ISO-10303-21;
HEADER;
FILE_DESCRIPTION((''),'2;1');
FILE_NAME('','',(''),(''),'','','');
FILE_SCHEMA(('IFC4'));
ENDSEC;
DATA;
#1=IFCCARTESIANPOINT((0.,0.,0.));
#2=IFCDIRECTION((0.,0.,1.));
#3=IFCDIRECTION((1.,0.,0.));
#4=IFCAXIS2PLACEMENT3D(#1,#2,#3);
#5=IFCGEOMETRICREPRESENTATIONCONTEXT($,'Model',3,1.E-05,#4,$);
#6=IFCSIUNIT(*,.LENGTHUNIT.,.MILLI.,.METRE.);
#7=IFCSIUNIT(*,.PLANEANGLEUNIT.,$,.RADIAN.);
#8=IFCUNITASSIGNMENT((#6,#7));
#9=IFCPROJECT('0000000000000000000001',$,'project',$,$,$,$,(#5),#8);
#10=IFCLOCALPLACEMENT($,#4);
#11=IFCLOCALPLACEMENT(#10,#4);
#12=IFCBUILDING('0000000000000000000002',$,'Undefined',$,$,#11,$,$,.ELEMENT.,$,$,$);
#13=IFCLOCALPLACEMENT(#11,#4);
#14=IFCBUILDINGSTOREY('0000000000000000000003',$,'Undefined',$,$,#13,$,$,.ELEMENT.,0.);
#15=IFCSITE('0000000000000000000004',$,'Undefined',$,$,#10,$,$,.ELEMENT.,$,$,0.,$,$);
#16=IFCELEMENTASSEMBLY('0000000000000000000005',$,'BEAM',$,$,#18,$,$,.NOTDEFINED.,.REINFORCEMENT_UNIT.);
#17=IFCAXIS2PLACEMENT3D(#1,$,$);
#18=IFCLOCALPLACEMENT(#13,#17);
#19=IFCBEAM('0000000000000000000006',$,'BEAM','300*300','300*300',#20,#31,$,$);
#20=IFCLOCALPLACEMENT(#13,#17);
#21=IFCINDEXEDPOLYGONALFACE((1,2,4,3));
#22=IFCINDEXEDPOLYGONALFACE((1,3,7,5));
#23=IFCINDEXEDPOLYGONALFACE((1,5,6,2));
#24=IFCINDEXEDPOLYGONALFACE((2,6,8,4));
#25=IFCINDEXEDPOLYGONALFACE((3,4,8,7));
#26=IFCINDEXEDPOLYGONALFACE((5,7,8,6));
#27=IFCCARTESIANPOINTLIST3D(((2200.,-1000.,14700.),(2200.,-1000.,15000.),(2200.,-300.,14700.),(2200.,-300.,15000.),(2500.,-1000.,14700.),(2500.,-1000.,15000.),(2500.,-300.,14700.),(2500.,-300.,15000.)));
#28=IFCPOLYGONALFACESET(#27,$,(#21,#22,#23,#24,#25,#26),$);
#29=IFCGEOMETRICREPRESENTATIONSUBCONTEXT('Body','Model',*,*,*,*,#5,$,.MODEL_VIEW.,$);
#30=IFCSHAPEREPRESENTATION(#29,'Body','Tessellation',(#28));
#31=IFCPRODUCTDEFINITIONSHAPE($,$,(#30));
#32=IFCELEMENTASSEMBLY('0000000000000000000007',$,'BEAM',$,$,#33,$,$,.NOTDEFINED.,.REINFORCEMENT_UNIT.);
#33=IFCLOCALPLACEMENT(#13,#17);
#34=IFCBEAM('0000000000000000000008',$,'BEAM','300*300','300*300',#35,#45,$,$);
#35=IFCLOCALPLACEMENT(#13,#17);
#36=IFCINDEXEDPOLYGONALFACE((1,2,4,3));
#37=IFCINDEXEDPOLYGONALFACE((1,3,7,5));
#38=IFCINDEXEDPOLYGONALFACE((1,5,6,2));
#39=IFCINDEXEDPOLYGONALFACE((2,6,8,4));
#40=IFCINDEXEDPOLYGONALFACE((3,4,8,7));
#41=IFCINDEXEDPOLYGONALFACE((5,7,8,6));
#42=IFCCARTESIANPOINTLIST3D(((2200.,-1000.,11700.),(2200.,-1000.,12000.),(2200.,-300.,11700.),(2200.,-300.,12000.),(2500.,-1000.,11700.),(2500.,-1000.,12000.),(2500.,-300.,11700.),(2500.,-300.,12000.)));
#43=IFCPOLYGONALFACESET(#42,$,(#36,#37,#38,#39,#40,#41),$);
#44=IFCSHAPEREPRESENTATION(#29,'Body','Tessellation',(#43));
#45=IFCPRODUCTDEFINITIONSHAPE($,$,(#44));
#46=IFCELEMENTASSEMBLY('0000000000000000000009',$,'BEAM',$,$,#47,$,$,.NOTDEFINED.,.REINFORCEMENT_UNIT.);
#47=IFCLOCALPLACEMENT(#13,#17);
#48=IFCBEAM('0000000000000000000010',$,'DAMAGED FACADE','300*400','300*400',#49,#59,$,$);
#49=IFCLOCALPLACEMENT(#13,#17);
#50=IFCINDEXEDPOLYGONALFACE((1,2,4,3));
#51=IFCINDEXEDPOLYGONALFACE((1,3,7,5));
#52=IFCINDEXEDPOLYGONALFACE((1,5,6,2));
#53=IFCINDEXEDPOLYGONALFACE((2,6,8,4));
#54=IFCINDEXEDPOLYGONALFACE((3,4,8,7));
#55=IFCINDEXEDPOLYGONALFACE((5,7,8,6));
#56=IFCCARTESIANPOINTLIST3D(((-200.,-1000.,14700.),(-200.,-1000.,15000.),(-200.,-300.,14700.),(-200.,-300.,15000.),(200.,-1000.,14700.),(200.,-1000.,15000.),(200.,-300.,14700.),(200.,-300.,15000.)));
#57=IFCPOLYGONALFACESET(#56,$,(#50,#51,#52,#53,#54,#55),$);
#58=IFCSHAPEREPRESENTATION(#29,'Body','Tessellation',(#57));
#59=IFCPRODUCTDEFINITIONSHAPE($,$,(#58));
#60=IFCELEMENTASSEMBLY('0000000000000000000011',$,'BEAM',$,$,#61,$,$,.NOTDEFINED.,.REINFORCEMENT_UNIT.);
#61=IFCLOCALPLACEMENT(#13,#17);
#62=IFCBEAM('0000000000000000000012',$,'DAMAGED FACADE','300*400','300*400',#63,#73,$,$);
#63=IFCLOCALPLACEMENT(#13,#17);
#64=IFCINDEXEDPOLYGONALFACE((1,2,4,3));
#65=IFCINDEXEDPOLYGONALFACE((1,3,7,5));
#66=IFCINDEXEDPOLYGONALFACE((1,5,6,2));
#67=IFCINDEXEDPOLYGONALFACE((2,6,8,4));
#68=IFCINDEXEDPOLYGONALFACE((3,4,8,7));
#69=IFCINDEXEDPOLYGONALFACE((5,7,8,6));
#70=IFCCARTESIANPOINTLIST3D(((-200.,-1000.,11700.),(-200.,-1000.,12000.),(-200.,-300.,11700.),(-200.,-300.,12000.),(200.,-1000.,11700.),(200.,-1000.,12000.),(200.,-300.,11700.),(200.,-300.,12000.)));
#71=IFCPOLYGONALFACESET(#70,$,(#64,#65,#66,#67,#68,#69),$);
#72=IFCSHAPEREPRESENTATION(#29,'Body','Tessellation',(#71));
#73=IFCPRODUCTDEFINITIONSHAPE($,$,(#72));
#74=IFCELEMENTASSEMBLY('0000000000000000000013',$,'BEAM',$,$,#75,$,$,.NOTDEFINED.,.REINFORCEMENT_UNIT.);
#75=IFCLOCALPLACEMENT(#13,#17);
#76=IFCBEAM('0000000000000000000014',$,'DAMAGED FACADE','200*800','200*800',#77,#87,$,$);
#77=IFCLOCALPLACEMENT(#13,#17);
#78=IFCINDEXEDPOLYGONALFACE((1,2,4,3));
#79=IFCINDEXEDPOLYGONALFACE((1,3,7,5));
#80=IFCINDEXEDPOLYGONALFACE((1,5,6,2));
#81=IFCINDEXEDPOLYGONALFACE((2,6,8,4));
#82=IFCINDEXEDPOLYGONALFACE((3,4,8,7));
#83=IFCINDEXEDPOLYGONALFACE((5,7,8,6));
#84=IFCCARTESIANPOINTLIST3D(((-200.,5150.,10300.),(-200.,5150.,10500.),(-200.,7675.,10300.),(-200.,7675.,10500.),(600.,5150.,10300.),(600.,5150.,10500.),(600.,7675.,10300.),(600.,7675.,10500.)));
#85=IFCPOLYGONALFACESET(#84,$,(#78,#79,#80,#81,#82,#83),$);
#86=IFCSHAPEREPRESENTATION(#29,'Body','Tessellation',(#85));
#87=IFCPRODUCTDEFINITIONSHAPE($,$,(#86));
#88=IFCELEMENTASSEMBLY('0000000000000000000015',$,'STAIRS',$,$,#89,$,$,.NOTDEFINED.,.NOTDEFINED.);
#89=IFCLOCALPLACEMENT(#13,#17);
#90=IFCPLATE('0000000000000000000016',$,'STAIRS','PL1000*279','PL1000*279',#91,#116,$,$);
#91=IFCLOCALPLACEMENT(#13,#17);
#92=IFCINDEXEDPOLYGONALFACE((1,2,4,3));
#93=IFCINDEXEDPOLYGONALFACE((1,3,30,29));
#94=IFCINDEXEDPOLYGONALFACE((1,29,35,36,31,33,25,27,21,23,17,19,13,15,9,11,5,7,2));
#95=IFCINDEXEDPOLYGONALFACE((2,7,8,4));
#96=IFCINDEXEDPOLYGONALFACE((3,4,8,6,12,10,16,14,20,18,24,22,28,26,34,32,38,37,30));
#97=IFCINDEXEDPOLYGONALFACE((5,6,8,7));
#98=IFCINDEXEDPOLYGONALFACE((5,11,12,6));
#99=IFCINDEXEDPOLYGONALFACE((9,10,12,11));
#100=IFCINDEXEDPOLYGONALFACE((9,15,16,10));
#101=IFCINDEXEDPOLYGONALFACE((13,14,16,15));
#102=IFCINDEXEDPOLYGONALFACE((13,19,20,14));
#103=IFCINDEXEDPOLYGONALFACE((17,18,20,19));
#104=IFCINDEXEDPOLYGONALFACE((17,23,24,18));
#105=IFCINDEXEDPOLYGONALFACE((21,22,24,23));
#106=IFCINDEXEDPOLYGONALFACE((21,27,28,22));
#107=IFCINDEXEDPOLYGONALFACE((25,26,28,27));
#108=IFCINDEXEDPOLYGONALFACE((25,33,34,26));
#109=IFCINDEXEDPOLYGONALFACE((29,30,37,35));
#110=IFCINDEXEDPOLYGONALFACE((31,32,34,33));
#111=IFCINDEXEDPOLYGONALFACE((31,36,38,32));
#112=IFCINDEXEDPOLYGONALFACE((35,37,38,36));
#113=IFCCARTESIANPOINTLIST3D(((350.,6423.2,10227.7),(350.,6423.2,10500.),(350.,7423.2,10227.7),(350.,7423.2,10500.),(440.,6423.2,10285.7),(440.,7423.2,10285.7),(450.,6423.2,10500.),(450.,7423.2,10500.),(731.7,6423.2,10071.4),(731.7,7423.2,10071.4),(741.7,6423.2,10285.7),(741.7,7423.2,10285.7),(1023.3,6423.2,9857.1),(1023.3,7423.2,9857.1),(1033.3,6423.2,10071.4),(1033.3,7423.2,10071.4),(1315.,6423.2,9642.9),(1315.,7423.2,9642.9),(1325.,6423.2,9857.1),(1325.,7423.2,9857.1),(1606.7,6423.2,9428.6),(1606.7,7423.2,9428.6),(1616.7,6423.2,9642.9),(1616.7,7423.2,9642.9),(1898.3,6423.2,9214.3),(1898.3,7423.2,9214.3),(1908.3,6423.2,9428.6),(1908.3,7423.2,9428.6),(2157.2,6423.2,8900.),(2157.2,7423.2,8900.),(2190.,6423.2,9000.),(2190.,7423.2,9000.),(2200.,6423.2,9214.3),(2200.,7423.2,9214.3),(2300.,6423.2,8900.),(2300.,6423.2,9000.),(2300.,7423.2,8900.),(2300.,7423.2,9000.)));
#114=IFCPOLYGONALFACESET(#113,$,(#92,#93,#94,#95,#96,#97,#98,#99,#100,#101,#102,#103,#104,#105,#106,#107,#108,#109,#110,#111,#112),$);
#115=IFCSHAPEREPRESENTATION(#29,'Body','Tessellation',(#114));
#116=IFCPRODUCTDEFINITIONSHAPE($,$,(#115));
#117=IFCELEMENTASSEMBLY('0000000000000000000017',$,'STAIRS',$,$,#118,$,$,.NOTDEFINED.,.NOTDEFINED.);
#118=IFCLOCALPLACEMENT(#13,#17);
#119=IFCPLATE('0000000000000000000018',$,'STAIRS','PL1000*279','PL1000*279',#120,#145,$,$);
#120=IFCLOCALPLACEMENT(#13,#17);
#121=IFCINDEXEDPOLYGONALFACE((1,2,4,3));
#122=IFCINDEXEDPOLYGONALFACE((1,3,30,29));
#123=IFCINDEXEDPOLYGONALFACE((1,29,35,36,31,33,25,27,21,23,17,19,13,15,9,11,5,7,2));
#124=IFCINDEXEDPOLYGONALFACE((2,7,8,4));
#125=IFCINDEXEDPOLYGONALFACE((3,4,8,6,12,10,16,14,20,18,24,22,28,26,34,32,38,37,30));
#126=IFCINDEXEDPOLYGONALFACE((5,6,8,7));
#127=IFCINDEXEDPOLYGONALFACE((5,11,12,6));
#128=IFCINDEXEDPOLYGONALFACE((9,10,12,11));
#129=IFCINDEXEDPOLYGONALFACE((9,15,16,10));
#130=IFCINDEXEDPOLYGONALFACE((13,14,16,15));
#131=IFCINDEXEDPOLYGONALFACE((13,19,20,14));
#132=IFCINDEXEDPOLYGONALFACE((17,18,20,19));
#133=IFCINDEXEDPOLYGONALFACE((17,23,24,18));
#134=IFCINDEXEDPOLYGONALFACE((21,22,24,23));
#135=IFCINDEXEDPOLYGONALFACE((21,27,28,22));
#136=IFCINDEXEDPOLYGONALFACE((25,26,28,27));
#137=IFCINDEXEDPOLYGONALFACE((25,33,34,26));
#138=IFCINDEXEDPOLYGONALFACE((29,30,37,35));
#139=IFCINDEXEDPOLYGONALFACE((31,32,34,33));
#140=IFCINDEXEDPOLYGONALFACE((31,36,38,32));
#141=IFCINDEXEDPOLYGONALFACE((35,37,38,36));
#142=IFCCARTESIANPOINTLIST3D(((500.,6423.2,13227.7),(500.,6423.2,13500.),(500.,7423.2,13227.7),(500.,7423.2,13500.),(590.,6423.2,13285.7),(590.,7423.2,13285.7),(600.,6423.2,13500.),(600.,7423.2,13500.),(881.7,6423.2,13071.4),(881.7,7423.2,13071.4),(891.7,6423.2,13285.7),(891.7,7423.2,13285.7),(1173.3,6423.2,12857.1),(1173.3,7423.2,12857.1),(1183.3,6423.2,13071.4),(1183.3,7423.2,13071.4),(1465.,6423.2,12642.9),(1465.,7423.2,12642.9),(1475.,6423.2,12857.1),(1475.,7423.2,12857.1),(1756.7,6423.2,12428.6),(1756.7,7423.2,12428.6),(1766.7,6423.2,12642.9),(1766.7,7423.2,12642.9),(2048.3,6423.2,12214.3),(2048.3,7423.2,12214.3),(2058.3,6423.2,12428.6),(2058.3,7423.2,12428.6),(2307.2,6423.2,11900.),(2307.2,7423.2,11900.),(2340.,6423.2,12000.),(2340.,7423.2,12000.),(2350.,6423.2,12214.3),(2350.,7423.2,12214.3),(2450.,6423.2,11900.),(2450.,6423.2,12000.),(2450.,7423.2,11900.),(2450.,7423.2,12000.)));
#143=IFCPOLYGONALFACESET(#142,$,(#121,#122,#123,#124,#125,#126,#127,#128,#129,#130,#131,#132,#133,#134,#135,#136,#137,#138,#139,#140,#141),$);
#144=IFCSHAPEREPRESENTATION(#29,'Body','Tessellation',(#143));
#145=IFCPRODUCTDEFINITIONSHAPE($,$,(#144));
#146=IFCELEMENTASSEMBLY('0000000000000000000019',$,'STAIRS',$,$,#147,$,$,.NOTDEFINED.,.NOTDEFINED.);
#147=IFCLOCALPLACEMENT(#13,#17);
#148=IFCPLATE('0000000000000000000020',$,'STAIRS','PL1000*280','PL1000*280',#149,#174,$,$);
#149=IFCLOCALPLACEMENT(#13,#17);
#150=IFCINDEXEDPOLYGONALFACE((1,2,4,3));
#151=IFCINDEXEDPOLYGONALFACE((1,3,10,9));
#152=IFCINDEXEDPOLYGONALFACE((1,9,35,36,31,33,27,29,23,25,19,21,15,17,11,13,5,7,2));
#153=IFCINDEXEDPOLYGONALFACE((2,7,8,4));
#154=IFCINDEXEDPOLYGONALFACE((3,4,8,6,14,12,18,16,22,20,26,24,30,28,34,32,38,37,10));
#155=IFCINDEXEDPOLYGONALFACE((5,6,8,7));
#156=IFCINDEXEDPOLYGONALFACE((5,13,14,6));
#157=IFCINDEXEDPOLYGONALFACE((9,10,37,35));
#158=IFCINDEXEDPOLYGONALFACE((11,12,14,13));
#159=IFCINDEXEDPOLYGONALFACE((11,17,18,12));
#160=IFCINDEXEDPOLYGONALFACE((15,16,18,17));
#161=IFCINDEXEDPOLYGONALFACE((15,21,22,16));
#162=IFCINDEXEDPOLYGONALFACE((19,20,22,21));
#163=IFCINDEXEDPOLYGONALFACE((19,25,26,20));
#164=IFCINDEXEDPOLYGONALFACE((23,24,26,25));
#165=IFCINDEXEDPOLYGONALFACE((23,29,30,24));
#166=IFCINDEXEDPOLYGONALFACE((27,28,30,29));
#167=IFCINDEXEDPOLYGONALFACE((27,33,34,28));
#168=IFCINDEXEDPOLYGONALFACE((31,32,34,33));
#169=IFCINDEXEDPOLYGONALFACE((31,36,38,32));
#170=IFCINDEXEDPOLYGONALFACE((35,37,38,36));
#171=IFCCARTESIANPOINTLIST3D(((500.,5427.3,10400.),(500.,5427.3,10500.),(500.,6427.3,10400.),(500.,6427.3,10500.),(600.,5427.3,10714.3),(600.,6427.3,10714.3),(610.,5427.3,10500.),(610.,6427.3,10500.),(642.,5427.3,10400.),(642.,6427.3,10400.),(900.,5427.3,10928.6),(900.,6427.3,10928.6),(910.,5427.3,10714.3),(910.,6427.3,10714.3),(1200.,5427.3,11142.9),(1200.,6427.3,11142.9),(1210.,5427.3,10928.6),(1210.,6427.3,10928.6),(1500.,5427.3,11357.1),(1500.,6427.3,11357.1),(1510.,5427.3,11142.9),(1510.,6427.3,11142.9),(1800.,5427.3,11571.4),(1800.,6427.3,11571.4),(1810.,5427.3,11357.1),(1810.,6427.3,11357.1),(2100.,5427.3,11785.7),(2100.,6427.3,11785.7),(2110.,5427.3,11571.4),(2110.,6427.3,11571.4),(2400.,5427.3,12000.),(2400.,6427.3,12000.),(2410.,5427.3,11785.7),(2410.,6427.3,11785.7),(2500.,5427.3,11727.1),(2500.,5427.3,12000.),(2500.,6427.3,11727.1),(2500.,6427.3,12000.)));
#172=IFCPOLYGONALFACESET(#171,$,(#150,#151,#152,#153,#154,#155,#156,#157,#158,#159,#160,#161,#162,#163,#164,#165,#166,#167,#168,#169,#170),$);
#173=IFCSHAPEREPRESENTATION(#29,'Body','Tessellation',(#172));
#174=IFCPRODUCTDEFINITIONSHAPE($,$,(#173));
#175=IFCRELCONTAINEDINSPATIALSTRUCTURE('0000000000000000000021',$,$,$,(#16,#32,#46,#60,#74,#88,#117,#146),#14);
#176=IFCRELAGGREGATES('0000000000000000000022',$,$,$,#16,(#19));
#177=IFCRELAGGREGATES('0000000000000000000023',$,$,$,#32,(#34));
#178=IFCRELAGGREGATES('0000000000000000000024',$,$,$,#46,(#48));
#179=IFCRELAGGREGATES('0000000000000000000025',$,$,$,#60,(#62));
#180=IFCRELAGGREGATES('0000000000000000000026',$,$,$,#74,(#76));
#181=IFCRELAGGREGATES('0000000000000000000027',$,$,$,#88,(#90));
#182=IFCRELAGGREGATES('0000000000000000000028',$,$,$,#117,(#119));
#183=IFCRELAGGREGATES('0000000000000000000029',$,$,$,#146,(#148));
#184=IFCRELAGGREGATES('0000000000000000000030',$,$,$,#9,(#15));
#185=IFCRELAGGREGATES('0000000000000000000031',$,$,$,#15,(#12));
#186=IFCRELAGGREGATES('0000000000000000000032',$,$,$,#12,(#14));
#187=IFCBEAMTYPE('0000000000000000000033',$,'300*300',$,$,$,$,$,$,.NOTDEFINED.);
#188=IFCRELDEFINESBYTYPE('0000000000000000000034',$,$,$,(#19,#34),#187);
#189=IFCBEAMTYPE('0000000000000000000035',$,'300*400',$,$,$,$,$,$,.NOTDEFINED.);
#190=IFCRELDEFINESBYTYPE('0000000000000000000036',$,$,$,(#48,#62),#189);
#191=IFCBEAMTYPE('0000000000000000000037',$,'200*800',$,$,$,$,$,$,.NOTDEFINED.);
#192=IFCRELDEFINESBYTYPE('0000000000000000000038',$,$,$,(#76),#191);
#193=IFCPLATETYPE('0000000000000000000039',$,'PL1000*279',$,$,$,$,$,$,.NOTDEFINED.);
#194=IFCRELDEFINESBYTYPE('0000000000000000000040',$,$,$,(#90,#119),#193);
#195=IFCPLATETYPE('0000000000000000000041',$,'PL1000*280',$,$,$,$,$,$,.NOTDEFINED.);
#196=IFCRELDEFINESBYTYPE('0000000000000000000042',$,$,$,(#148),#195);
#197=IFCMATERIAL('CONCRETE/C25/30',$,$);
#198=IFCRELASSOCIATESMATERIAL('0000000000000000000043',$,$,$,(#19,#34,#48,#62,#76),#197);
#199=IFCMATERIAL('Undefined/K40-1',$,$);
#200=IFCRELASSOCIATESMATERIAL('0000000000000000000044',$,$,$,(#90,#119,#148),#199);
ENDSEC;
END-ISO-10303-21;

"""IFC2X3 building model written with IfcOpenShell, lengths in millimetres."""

from ifc_helpers import new_model, si_unit, frame, origin_with_axes, origin_2d_with_axis, place, context, subcontext, project, spatial, polyline, rectangle, outline, extrude, material, type_object, element, aggregate, save


model = new_model("IFC2X3")

# Units and contexts
model_context = context("Model", 3, precision=1e-05, world=origin_with_axes())
body_context = subcontext(model_context, "Body", "Model", "MODEL_VIEW")
ifc_project = project(units=[si_unit("LENGTHUNIT", "METRE", prefix="MILLI"), si_unit("PLANEANGLEUNIT", "RADIAN")], contexts=[model_context])

# Site, building, storey
site_placement = place(None, origin_with_axes())
site = spatial("IfcSite", under=ifc_project, at=site_placement, Name="Undefined", CompositionType="ELEMENT", RefElevation=0.0)
building_placement = place(site_placement, origin_with_axes())
building = spatial("IfcBuilding", under=site, at=building_placement, Name="Undefined", CompositionType="ELEMENT")
storey_placement = place(building_placement, origin_with_axes())
storey = spatial("IfcBuildingStorey", under=building, at=storey_placement, Name="Undefined", CompositionType="ELEMENT", Elevation=0.0)

# Shared definitions
ifc_material_1 = material(Name="CONCRETE/C25/30")

# Element assemblies, beams
beam_type_1 = type_object("IfcBeamType", Name="300*300", PredefinedType="NOTDEFINED")
assembly_1_placement = place(storey_placement, origin_with_axes())
assembly_1 = element("IfcElementAssembly", 1, at=assembly_1_placement, inside=storey, Name="BEAM", AssemblyPlace="NOTDEFINED", PredefinedType="REINFORCEMENT_UNIT")
beam_1_placement = place(assembly_1_placement, frame((2350.0, -300.0, 14850.0), z_axis=(0.0, 0.0, 1.0), x_axis=(0.0, -1.0, 0.0)))
beam_1 = element("IfcBeam", 2, at=beam_1_placement, type_object=beam_type_1, material=ifc_material_1, Name="BEAM", Description="300*300", ObjectType="300*300", context=body_context, shape_type="SweptSolid", body=[
    extrude(rectangle(XDim=300.0, YDim=300.0, at=origin_2d_with_axis()), frame((700.0, 0.0, 0.0), z_axis=(-1.0, 0.0, 0.0), x_axis=(0.0, -1.0, 0.0)), (0.0, 0.0, 1.0), 700.0),
])
aggregate(assembly_1, [beam_1])
assembly_2_placement = place(storey_placement, origin_with_axes())
assembly_2 = element("IfcElementAssembly", 3, at=assembly_2_placement, inside=storey, Name="BEAM", AssemblyPlace="NOTDEFINED", PredefinedType="REINFORCEMENT_UNIT")
beam_2_placement = place(assembly_2_placement, frame((2350.0, -300.0, 11850.0), z_axis=(0.0, 0.0, 1.0), x_axis=(0.0, -1.0, 0.0)))
beam_2 = element("IfcBeam", 4, at=beam_2_placement, type_object=beam_type_1, material=ifc_material_1, Name="BEAM", Description="300*300", ObjectType="300*300", context=body_context, shape_type="SweptSolid", body=[
    extrude(rectangle(XDim=300.0, YDim=300.0, at=origin_2d_with_axis()), frame((700.0, 0.0, 0.0), z_axis=(-1.0, 0.0, 0.0), x_axis=(0.0, -1.0, 0.0)), (0.0, 0.0, 1.0), 700.0),
])
aggregate(assembly_2, [beam_2])
assembly_3_placement = place(storey_placement, origin_with_axes())
assembly_3 = element("IfcElementAssembly", 5, at=assembly_3_placement, inside=storey, Name="BEAM", AssemblyPlace="NOTDEFINED", PredefinedType="REINFORCEMENT_UNIT")
beam_type_2 = type_object("IfcBeamType", Name="300*400", PredefinedType="NOTDEFINED")
beam_3_placement = place(assembly_3_placement, frame((0.0, -300.0, 14850.0), z_axis=(0.0, 0.0, 1.0), x_axis=(0.0, -1.0, 0.0)))
beam_3 = element("IfcBeam", 6, at=beam_3_placement, type_object=beam_type_2, material=ifc_material_1, Name="DAMAGED FACADE", Description="300*400", ObjectType="300*400", context=body_context, shape_type="SweptSolid", body=[
    extrude(rectangle(XDim=400.0, YDim=300.0, at=origin_2d_with_axis()), frame((700.0, 0.0, 0.0), z_axis=(-1.0, 0.0, 0.0), x_axis=(0.0, -1.0, 0.0)), (0.0, 0.0, 1.0), 700.0),
])
aggregate(assembly_3, [beam_3])
assembly_4_placement = place(storey_placement, origin_with_axes())
assembly_4 = element("IfcElementAssembly", 7, at=assembly_4_placement, inside=storey, Name="BEAM", AssemblyPlace="NOTDEFINED", PredefinedType="REINFORCEMENT_UNIT")
beam_4_placement = place(assembly_4_placement, frame((0.0, -300.0, 11850.0), z_axis=(0.0, 0.0, 1.0), x_axis=(0.0, -1.0, 0.0)))
beam_4 = element("IfcBeam", 8, at=beam_4_placement, type_object=beam_type_2, material=ifc_material_1, Name="DAMAGED FACADE", Description="300*400", ObjectType="300*400", context=body_context, shape_type="SweptSolid", body=[
    extrude(rectangle(XDim=400.0, YDim=300.0, at=origin_2d_with_axis()), frame((700.0, 0.0, 0.0), z_axis=(-1.0, 0.0, 0.0), x_axis=(0.0, -1.0, 0.0)), (0.0, 0.0, 1.0), 700.0),
])
aggregate(assembly_4, [beam_4])
assembly_5_placement = place(storey_placement, origin_with_axes())
assembly_5 = element("IfcElementAssembly", 9, at=assembly_5_placement, inside=storey, Name="BEAM", AssemblyPlace="NOTDEFINED", PredefinedType="REINFORCEMENT_UNIT")
beam_type_3 = type_object("IfcBeamType", Name="200*800", PredefinedType="NOTDEFINED")
beam_5_placement = place(assembly_5_placement, frame((200.0, 7675.0, 10400.0), z_axis=(0.0, 0.0, 1.0), x_axis=(0.0, -1.0, 0.0)))
beam_5 = element("IfcBeam", 10, at=beam_5_placement, type_object=beam_type_3, material=ifc_material_1, Name="DAMAGED FACADE", Description="200*800", ObjectType="200*800", context=body_context, shape_type="SweptSolid", body=[
    extrude(rectangle(XDim=800.0, YDim=200.0, at=origin_2d_with_axis()), frame((2525.0, 0.0, 0.0), z_axis=(-1.0, 0.0, 0.0), x_axis=(0.0, -1.0, 0.0)), (0.0, 0.0, 1.0), 2525.0),
])
aggregate(assembly_5, [beam_5])

# Element assemblies, plates
assembly_6_placement = place(storey_placement, origin_with_axes())
assembly_6 = element("IfcElementAssembly", 11, at=assembly_6_placement, inside=storey, Name="STAIRS", AssemblyPlace="NOTDEFINED", PredefinedType="NOTDEFINED")
ifc_material_2 = material(Name="Undefined/K40-1")
plate_type_1 = type_object("IfcPlateType", Name="PL1000*279", PredefinedType="NOTDEFINED")
plate_1_placement = place(assembly_6_placement, frame((2190.0, 6923.2, 9000.0), z_axis=(0.0, 1.0, 0.0), x_axis=(1.0, 0.0, 0.0)))
plate_1 = element("IfcPlate", 12, at=plate_1_placement, type_object=plate_type_1, material=ifc_material_2, Name="STAIRS", Description="PL1000*279", ObjectType="PL1000*279", context=body_context, shape_type="SweptSolid", body=[
    extrude(outline(polyline([(0.0, 0.0), (110.0, 0.0), (110.0, 100.0), (-32.8, 100.0), (-1840.0, -1227.7), (-1840.0, -1500.0), (-1740.0, -1500.0), (-1750.0, -1285.7), (-1448.3, -1285.7), (-1458.3, -1071.4), (-1156.7, -1071.4), (-1166.7, -857.1), (-865.0, -857.1), (-875.0, -642.9), (-573.3, -642.9), (-583.3, -428.6), (-281.7, -428.6), (-291.7, -214.3), (10.0, -214.3), (0.0, 0.0), (0.0, 0.0)])), frame((0.0, 0.0, -500.0), z_axis=(0.0, 0.0, 1.0), x_axis=(1.0, 0.0, 0.0)), (0.0, 0.0, 1.0), 1000.0),
])
aggregate(assembly_6, [plate_1])
assembly_7_placement = place(storey_placement, origin_with_axes())
assembly_7 = element("IfcElementAssembly", 13, at=assembly_7_placement, inside=storey, Name="STAIRS", AssemblyPlace="NOTDEFINED", PredefinedType="NOTDEFINED")
plate_2_placement = place(assembly_7_placement, frame((2340.0, 6923.2, 12000.0), z_axis=(0.0, 1.0, 0.0), x_axis=(1.0, 0.0, 0.0)))
plate_2 = element("IfcPlate", 14, at=plate_2_placement, type_object=plate_type_1, material=ifc_material_2, Name="STAIRS", Description="PL1000*279", ObjectType="PL1000*279", context=body_context, shape_type="SweptSolid", body=[
    extrude(outline(polyline([(0.0, 0.0), (110.0, 0.0), (110.0, 100.0), (-32.8, 100.0), (-1840.0, -1227.7), (-1840.0, -1500.0), (-1740.0, -1500.0), (-1750.0, -1285.7), (-1448.3, -1285.7), (-1458.3, -1071.4), (-1156.7, -1071.4), (-1166.7, -857.1), (-865.0, -857.1), (-875.0, -642.9), (-573.3, -642.9), (-583.3, -428.6), (-281.7, -428.6), (-291.7, -214.3), (10.0, -214.3), (0.0, 0.0), (0.0, 0.0)])), frame((0.0, 0.0, -500.0), z_axis=(0.0, 0.0, 1.0), x_axis=(1.0, 0.0, 0.0)), (0.0, 0.0, 1.0), 1000.0),
])
aggregate(assembly_7, [plate_2])
assembly_8_placement = place(storey_placement, origin_with_axes())
assembly_8 = element("IfcElementAssembly", 15, at=assembly_8_placement, inside=storey, Name="STAIRS", AssemblyPlace="NOTDEFINED", PredefinedType="NOTDEFINED")
plate_type_2 = type_object("IfcPlateType", Name="PL1000*280", PredefinedType="NOTDEFINED")
plate_3_placement = place(assembly_8_placement, frame((610.0, 5927.3, 10500.0), z_axis=(0.0, -1.0, 0.0), x_axis=(-1.0, 0.0, 0.0)))
plate_3 = element("IfcPlate", 16, at=plate_3_placement, type_object=plate_type_2, material=ifc_material_2, Name="STAIRS", Description="PL1000*280", ObjectType="PL1000*280", context=body_context, shape_type="SweptSolid", body=[
    extrude(outline(polyline([(0.0, 0.0), (110.0, 0.0), (110.0, 100.0), (-32.0, 100.0), (-1890.0, -1227.1), (-1890.0, -1500.0), (-1790.0, -1500.0), (-1800.0, -1285.7), (-1490.0, -1285.7), (-1500.0, -1071.4), (-1190.0, -1071.4), (-1200.0, -857.1), (-890.0, -857.1), (-900.0, -642.9), (-590.0, -642.9), (-600.0, -428.6), (-290.0, -428.6), (-300.0, -214.3), (10.0, -214.3), (0.0, 0.0), (0.0, 0.0)])), frame((0.0, 0.0, -500.0), z_axis=(0.0, 0.0, 1.0), x_axis=(1.0, 0.0, 0.0)), (0.0, 0.0, 1.0), 1000.0),
])
aggregate(assembly_8, [plate_3])

save(model, "model.ifc")
